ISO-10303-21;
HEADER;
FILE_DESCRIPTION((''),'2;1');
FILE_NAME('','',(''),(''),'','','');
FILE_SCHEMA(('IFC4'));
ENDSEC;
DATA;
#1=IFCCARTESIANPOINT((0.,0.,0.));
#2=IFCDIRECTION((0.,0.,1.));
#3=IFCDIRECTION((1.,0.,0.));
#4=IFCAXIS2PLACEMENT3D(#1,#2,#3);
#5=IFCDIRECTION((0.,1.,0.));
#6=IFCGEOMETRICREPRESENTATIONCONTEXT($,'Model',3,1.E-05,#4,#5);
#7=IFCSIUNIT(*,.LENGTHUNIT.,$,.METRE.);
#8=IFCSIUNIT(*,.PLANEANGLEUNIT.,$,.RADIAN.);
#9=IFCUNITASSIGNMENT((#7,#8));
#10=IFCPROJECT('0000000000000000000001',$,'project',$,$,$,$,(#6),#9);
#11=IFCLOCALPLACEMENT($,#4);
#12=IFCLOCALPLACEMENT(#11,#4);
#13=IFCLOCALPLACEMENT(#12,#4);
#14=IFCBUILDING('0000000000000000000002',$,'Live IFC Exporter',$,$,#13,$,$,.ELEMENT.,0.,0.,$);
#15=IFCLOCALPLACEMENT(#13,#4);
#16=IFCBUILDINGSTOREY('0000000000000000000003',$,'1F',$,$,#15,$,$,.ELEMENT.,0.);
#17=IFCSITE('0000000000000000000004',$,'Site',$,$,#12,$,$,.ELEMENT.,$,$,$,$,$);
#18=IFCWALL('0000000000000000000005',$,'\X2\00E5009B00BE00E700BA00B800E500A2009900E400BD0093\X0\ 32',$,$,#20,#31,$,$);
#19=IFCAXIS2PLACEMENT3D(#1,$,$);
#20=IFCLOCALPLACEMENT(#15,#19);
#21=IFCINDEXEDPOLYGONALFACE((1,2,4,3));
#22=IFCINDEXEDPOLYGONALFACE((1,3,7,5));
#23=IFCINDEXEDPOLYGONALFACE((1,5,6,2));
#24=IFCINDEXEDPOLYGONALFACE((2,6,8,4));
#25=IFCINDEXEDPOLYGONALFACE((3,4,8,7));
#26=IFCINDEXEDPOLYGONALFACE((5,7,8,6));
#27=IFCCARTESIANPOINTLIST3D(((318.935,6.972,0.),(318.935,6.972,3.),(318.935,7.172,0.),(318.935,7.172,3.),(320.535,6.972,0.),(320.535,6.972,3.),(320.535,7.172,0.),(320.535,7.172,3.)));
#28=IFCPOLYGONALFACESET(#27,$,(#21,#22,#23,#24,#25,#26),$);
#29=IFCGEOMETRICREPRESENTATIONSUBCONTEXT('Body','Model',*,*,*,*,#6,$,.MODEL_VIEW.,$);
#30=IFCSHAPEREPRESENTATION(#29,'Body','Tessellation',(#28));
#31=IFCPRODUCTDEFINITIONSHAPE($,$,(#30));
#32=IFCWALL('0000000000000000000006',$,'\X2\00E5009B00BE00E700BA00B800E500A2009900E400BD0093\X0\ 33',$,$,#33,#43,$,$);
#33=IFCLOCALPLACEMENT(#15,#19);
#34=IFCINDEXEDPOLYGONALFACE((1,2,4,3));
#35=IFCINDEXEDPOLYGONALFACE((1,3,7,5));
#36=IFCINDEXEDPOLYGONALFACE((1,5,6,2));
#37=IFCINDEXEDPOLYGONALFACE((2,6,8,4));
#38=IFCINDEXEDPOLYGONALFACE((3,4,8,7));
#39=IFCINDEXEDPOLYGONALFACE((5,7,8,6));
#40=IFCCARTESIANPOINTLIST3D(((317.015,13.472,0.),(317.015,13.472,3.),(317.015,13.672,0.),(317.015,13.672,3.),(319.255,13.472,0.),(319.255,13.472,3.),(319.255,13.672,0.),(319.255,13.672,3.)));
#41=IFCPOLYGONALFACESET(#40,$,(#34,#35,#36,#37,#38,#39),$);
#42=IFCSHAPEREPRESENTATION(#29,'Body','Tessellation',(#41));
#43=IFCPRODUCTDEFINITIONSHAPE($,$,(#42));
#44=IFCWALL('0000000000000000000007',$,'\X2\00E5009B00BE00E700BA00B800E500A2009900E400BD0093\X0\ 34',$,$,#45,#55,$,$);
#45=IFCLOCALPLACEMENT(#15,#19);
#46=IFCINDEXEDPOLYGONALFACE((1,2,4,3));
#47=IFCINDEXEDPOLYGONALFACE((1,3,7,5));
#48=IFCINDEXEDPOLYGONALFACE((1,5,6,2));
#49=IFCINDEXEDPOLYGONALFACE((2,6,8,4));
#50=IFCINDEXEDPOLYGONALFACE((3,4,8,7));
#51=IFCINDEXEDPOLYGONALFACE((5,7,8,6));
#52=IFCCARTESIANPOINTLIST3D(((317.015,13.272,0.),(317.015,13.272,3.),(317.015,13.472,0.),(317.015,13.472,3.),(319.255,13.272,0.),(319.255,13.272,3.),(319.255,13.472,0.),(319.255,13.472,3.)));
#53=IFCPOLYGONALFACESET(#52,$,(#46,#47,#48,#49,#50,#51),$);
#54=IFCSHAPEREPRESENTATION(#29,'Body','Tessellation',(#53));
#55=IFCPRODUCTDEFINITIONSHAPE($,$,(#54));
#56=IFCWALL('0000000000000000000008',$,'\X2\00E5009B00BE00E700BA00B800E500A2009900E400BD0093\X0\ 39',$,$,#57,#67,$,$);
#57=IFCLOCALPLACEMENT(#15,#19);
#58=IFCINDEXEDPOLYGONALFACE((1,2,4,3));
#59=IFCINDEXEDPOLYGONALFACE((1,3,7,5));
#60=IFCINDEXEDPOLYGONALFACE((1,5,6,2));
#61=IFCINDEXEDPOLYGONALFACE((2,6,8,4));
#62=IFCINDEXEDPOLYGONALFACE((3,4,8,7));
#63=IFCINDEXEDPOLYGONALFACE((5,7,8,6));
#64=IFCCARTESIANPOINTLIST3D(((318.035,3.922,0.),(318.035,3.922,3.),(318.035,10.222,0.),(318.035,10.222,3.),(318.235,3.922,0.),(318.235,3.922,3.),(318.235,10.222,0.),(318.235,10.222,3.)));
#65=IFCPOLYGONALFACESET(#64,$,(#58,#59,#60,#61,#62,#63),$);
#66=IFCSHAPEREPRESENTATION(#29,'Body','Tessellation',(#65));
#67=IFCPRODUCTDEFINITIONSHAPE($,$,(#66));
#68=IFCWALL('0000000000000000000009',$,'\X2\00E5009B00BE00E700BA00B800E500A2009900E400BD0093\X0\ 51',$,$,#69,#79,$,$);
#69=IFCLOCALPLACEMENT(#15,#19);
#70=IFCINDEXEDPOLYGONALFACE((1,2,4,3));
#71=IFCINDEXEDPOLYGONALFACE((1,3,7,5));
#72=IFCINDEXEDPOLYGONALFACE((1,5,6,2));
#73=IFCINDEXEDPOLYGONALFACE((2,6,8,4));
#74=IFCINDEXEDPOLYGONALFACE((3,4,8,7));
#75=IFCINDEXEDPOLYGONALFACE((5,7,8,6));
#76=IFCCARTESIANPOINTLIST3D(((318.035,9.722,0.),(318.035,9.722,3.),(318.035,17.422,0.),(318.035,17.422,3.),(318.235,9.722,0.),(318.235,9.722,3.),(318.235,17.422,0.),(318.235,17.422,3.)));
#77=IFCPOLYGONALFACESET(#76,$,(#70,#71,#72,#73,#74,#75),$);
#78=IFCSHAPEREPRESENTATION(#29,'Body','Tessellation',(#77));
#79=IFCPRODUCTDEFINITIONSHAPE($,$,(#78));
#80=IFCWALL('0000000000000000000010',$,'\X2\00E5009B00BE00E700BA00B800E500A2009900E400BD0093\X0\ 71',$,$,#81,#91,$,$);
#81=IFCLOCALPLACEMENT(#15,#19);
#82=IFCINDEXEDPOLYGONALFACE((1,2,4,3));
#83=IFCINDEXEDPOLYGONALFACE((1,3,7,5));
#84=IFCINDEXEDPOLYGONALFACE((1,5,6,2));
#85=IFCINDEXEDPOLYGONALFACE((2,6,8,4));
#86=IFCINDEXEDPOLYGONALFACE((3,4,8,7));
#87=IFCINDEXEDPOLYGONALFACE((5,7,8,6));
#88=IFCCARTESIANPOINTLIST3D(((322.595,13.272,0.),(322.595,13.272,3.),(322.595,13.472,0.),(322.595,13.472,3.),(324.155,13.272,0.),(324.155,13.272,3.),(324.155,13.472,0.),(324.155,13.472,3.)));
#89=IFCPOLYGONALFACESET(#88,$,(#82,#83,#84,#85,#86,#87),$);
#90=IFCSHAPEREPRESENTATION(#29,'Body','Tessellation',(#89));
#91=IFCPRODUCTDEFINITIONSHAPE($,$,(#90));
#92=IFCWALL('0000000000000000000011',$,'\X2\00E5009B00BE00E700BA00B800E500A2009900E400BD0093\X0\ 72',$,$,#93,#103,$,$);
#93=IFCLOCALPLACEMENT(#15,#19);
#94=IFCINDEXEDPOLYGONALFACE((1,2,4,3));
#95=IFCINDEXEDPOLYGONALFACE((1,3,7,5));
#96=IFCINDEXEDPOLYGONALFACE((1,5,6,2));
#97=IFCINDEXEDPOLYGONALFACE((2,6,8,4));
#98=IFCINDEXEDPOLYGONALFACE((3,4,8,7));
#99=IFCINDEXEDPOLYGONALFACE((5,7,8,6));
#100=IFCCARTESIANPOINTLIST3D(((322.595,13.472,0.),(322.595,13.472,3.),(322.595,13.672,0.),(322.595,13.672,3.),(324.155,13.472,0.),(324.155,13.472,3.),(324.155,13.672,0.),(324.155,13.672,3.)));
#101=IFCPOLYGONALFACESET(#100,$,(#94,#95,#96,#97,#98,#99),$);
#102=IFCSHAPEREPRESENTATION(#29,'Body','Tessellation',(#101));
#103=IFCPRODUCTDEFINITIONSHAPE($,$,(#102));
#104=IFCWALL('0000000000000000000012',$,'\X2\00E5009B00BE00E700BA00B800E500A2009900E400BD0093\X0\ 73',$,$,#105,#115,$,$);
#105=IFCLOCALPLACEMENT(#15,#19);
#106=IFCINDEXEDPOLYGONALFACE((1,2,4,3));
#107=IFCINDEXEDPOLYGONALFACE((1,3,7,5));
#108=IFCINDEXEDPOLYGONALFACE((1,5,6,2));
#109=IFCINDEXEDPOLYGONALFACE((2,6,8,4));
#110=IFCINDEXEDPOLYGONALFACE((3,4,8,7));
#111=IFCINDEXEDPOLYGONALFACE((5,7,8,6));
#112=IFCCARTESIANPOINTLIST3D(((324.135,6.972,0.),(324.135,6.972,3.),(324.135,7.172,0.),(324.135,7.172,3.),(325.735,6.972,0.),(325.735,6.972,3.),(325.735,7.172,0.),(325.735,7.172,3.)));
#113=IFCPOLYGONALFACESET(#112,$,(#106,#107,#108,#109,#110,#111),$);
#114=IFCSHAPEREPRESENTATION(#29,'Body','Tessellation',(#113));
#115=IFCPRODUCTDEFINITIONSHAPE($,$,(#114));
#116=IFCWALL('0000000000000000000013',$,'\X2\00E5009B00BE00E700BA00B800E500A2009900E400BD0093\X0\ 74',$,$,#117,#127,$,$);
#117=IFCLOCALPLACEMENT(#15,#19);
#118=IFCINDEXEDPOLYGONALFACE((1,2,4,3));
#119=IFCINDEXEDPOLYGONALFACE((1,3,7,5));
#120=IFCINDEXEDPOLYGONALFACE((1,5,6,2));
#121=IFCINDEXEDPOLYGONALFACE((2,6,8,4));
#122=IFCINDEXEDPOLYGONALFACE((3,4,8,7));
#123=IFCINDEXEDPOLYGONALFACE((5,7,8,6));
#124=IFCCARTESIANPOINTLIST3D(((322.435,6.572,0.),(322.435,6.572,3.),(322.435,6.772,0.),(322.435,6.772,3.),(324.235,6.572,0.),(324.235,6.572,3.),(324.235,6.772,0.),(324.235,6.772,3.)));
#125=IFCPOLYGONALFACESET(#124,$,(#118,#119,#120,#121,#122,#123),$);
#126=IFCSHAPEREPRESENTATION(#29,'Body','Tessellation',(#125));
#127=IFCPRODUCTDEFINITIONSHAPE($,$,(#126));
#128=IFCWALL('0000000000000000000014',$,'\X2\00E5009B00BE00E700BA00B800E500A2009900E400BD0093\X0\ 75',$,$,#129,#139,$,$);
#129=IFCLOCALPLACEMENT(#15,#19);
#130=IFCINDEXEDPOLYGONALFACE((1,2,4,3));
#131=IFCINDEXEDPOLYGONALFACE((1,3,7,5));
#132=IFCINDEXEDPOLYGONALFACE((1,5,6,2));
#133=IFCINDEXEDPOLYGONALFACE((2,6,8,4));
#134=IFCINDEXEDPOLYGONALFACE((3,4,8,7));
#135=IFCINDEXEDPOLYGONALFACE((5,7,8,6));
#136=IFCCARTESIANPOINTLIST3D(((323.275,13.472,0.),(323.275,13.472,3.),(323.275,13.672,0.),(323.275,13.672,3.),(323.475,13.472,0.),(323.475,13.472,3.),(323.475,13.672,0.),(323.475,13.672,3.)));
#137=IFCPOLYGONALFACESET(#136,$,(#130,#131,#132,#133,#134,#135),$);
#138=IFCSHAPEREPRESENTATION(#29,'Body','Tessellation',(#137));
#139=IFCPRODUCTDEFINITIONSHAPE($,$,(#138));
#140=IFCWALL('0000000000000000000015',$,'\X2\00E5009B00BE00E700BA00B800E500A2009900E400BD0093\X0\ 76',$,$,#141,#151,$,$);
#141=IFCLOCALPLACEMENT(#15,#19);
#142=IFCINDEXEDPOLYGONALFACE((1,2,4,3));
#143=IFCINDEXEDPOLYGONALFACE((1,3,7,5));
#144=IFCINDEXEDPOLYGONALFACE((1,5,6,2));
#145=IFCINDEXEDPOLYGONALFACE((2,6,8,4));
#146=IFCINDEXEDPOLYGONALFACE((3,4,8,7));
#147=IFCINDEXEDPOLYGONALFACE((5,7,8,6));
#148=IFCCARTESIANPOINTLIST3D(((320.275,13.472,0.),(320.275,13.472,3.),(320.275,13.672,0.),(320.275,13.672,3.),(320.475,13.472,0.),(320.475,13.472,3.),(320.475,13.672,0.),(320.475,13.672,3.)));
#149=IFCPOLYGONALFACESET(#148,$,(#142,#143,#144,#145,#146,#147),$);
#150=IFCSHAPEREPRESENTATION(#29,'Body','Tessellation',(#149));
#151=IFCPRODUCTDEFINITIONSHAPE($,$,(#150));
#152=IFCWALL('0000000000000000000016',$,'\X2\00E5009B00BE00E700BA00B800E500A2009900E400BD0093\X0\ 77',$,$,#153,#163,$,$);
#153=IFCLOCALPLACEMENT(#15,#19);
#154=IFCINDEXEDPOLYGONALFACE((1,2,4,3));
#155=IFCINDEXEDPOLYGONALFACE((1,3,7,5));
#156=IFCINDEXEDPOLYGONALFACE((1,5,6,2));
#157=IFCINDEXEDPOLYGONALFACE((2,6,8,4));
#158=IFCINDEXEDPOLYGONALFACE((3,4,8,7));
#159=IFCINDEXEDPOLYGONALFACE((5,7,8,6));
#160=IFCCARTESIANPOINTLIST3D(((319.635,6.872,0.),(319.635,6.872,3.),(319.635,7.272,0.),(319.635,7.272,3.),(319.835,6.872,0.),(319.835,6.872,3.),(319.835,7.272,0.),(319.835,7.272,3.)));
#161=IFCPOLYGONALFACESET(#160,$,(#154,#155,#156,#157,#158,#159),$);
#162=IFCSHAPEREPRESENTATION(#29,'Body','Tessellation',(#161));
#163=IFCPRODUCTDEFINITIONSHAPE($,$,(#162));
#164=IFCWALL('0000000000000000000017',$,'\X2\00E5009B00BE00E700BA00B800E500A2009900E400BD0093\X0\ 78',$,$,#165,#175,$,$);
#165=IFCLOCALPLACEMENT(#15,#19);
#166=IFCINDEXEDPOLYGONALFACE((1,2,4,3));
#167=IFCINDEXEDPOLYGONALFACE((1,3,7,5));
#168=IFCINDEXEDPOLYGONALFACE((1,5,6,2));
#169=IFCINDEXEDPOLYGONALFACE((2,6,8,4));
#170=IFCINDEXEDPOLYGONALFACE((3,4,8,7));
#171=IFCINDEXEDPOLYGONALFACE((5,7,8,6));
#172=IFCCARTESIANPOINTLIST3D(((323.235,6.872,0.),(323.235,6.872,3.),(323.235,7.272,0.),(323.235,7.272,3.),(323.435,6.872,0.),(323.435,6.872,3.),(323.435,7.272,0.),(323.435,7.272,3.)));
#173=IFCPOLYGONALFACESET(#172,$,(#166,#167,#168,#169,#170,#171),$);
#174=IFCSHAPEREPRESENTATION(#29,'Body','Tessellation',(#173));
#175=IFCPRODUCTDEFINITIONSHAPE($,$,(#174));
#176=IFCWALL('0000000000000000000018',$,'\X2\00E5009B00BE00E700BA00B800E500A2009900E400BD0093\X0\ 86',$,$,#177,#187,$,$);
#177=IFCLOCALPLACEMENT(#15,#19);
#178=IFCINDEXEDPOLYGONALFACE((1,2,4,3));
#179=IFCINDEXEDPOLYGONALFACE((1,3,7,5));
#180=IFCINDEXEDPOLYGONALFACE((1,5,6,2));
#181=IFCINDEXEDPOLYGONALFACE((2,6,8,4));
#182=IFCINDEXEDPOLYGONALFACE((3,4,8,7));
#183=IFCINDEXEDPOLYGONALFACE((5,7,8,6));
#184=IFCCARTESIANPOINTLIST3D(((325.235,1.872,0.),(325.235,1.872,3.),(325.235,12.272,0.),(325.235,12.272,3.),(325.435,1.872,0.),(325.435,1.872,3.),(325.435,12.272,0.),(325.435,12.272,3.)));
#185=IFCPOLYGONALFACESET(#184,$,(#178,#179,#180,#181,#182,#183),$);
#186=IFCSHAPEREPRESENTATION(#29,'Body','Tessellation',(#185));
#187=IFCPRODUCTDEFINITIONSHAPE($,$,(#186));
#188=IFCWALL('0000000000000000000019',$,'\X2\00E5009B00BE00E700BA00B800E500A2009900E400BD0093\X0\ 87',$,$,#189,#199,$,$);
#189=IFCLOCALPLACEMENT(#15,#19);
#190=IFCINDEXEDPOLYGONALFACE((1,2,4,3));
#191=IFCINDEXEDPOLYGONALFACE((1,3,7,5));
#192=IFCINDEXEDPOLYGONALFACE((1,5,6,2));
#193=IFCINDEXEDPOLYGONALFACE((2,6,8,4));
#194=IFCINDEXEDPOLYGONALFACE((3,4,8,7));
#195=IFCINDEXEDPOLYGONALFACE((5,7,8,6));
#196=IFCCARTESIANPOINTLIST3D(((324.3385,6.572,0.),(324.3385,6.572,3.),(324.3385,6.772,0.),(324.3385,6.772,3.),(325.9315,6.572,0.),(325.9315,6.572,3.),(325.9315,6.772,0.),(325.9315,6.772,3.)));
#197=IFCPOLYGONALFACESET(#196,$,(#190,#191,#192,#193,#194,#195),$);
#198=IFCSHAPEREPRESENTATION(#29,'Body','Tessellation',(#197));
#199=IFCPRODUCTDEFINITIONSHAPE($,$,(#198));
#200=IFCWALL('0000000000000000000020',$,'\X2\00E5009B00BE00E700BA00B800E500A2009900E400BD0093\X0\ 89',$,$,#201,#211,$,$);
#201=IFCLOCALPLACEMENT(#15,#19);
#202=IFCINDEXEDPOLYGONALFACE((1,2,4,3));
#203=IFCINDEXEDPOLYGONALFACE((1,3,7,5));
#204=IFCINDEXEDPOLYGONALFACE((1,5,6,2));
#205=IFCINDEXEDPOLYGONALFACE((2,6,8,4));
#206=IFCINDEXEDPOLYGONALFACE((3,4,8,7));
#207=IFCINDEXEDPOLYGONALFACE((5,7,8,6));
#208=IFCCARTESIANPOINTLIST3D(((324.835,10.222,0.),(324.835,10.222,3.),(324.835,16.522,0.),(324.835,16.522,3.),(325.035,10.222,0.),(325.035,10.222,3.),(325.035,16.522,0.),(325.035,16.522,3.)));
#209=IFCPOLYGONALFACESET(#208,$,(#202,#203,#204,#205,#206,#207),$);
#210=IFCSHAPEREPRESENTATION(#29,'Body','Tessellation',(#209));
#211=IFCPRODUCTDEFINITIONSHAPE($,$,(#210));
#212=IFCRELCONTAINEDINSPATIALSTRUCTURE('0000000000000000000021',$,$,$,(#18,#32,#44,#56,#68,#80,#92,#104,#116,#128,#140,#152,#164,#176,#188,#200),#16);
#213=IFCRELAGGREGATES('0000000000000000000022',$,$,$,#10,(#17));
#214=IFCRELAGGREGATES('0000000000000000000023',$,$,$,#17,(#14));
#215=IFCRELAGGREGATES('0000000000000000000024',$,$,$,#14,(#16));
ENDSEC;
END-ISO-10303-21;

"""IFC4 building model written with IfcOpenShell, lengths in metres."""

from ifc_helpers import new_model, si_unit, direction, frame, frame_2d, origin_with_axes, place, context, subcontext, project, spatial, rectangle, extrude, element, save


model = new_model("IFC4")

# Units and contexts
model_context = context("Model", 3, precision=1e-05, world=origin_with_axes(), true_north=direction((0.0, 1.0, 0.0)))
body_context = subcontext(model_context, "Body", "Model", "MODEL_VIEW")
ifc_project = project(units=[si_unit("LENGTHUNIT", "METRE"), si_unit("PLANEANGLEUNIT", "RADIAN")], contexts=[model_context])

# Site, building, storey
placement = place(None, origin_with_axes())
site_placement = place(placement, origin_with_axes())
site = spatial("IfcSite", under=ifc_project, at=site_placement, Name="Site", CompositionType="ELEMENT")
building_placement = place(site_placement, origin_with_axes())
building = spatial("IfcBuilding", under=site, at=building_placement, Name="Live IFC Exporter", CompositionType="ELEMENT", ElevationOfRefHeight=0.0, ElevationOfTerrain=0.0)
storey_placement = place(building_placement, origin_with_axes())
storey = spatial("IfcBuildingStorey", under=building, at=storey_placement, Name="1F", CompositionType="ELEMENT", Elevation=0.0)

# Walls
wall_1_placement = place(storey_placement, frame((319.735, 7.072, 0.0), z_axis=(0.0, 0.0, 1.0), x_axis=(-1.0, 0.0, 0.0)))
element("IfcWall", 1, at=wall_1_placement, inside=storey, Name="å\u009b¾çº¸å¢\u0099ä½\u0093 32", context=body_context, shape_type="SweptSolid", body=[
    extrude(rectangle(XDim=1.6, YDim=0.2, at=frame_2d((0.0, 0.0), x_axis=(1.0, 0.0, 0.0))), frame((0.0, 0.0, 0.0), z_axis=(0.0, 0.0, 1.0)), (0.0, 0.0, 1.0), 3.0),
])
for number, where, z_axis, x_axis, name in (
    (2, (318.135, 13.572, 0.0), (0.0, 0.0, 1.0), (1.0, 0.0, 0.0), "å\u009b¾çº¸å¢\u0099ä½\u0093 33"),
    (3, (318.135, 13.372, 0.0), (0.0, 0.0, 1.0), (1.0, 0.0, 0.0), "å\u009b¾çº¸å¢\u0099ä½\u0093 34"),
):
    element("IfcWall", number, at=place(storey_placement, frame(where, z_axis=z_axis, x_axis=x_axis)), inside=storey, Name=name, context=body_context, shape_type="SweptSolid", body=[
        extrude(rectangle(XDim=2.24, YDim=0.2, at=frame_2d((0.0, 0.0), x_axis=(1.0, 0.0, 0.0))), frame((0.0, 0.0, 0.0), z_axis=(0.0, 0.0, 1.0)), (0.0, 0.0, 1.0), 3.0),
    ])
wall_2_placement = place(storey_placement, frame((318.135, 7.072, 0.0), z_axis=(0.0, 0.0, 1.0), x_axis=(0.0, 1.0, 0.0)))
element("IfcWall", 4, at=wall_2_placement, inside=storey, Name="å\u009b¾çº¸å¢\u0099ä½\u0093 39", context=body_context, shape_type="SweptSolid", body=[
    extrude(rectangle(XDim=6.3, YDim=0.2, at=frame_2d((0.0, 0.0), x_axis=(1.0, 0.0, 0.0))), frame((0.0, 0.0, 0.0), z_axis=(0.0, 0.0, 1.0)), (0.0, 0.0, 1.0), 3.0),
])
wall_3_placement = place(storey_placement, frame((318.135, 13.572, 0.0), z_axis=(0.0, 0.0, 1.0), x_axis=(0.0, 1.0, 0.0)))
element("IfcWall", 5, at=wall_3_placement, inside=storey, Name="å\u009b¾çº¸å¢\u0099ä½\u0093 51", context=body_context, shape_type="SweptSolid", body=[
    extrude(rectangle(XDim=7.7, YDim=0.2, at=frame_2d((0.0, 0.0), x_axis=(1.0, 0.0, 0.0))), frame((0.0, 0.0, 0.0), z_axis=(0.0, 0.0, 1.0)), (0.0, 0.0, 1.0), 3.0),
])
for number, where, z_axis, x_axis, name in (
    (6, (323.375, 13.372, 0.0), (0.0, 0.0, 1.0), (1.0, 0.0, 0.0), "å\u009b¾çº¸å¢\u0099ä½\u0093 71"),
    (7, (323.375, 13.572, 0.0), (0.0, 0.0, 1.0), (1.0, 0.0, 0.0), "å\u009b¾çº¸å¢\u0099ä½\u0093 72"),
):
    element("IfcWall", number, at=place(storey_placement, frame(where, z_axis=z_axis, x_axis=x_axis)), inside=storey, Name=name, context=body_context, shape_type="SweptSolid", body=[
        extrude(rectangle(XDim=1.56, YDim=0.2, at=frame_2d((0.0, 0.0), x_axis=(1.0, 0.0, 0.0))), frame((0.0, 0.0, 0.0), z_axis=(0.0, 0.0, 1.0)), (0.0, 0.0, 1.0), 3.0),
    ])
wall_4_placement = place(storey_placement, frame((324.935, 7.072, 0.0), z_axis=(0.0, 0.0, 1.0), x_axis=(-1.0, 0.0, 0.0)))
element("IfcWall", 8, at=wall_4_placement, inside=storey, Name="å\u009b¾çº¸å¢\u0099ä½\u0093 73", context=body_context, shape_type="SweptSolid", body=[
    extrude(rectangle(XDim=1.6, YDim=0.2, at=frame_2d((0.0, 0.0), x_axis=(1.0, 0.0, 0.0))), frame((0.0, 0.0, 0.0), z_axis=(0.0, 0.0, 1.0)), (0.0, 0.0, 1.0), 3.0),
])
wall_5_placement = place(storey_placement, frame((323.335, 6.672, 0.0), z_axis=(0.0, 0.0, 1.0), x_axis=(1.0, 0.0, 0.0)))
element("IfcWall", 9, at=wall_5_placement, inside=storey, Name="å\u009b¾çº¸å¢\u0099ä½\u0093 74", context=body_context, shape_type="SweptSolid", body=[
    extrude(rectangle(XDim=1.8, YDim=0.2, at=frame_2d((0.0, 0.0), x_axis=(1.0, 0.0, 0.0))), frame((0.0, 0.0, 0.0), z_axis=(0.0, 0.0, 1.0)), (0.0, 0.0, 1.0), 3.0),
])
for number, where, z_axis, x_axis, name in (
    (10, (323.375, 13.572, 0.0), (0.0, 0.0, 1.0), (0.0, -1.0, 0.0), "å\u009b¾çº¸å¢\u0099ä½\u0093 75"),
    (11, (320.375, 13.572, 0.0), (0.0, 0.0, 1.0), (0.0, -1.0, 0.0), "å\u009b¾çº¸å¢\u0099ä½\u0093 76"),
):
    element("IfcWall", number, at=place(storey_placement, frame(where, z_axis=z_axis, x_axis=x_axis)), inside=storey, Name=name, context=body_context, shape_type="SweptSolid", body=[
        extrude(rectangle(XDim=0.2, YDim=0.2, at=frame_2d((0.0, 0.0), x_axis=(1.0, 0.0, 0.0))), frame((0.0, 0.0, 0.0), z_axis=(0.0, 0.0, 1.0)), (0.0, 0.0, 1.0), 3.0),
    ])
for number, where, z_axis, x_axis, name in (
    (12, (319.735, 7.072, 0.0), (0.0, 0.0, 1.0), (0.0, -1.0, 0.0), "å\u009b¾çº¸å¢\u0099ä½\u0093 77"),
    (13, (323.335, 7.072, 0.0), (0.0, 0.0, 1.0), (0.0, -1.0, 0.0), "å\u009b¾çº¸å¢\u0099ä½\u0093 78"),
):
    element("IfcWall", number, at=place(storey_placement, frame(where, z_axis=z_axis, x_axis=x_axis)), inside=storey, Name=name, context=body_context, shape_type="SweptSolid", body=[
        extrude(rectangle(XDim=0.4, YDim=0.2, at=frame_2d((0.0, 0.0), x_axis=(1.0, 0.0, 0.0))), frame((0.0, 0.0, 0.0), z_axis=(0.0, 0.0, 1.0)), (0.0, 0.0, 1.0), 3.0),
    ])
wall_6_placement = place(storey_placement, frame((325.335, 7.072, 0.0), z_axis=(0.0, 0.0, 1.0), x_axis=(0.0, 1.0, 0.0)))
element("IfcWall", 14, at=wall_6_placement, inside=storey, Name="å\u009b¾çº¸å¢\u0099ä½\u0093 86", context=body_context, shape_type="SweptSolid", body=[
    extrude(rectangle(XDim=10.4, YDim=0.2, at=frame_2d((0.0, 0.0), x_axis=(1.0, 0.0, 0.0))), frame((0.0, 0.0, 0.0), z_axis=(0.0, 0.0, 1.0)), (0.0, 0.0, 1.0), 3.0),
])
wall_7_placement = place(storey_placement, frame((325.135, 6.672, 0.0), z_axis=(0.0, 0.0, 1.0), x_axis=(1.0, 0.0, 0.0)))
element("IfcWall", 15, at=wall_7_placement, inside=storey, Name="å\u009b¾çº¸å¢\u0099ä½\u0093 87", context=body_context, shape_type="SweptSolid", body=[
    extrude(rectangle(XDim=1.593, YDim=0.2, at=frame_2d((0.0, 0.0), x_axis=(1.0, 0.0, 0.0))), frame((0.0, 0.0, 0.0), z_axis=(0.0, 0.0, 1.0)), (0.0, 0.0, 1.0), 3.0),
])
wall_8_placement = place(storey_placement, frame((324.935, 13.372, 0.0), z_axis=(0.0, 0.0, 1.0), x_axis=(0.0, -1.0, 0.0)))
element("IfcWall", 16, at=wall_8_placement, inside=storey, Name="å\u009b¾çº¸å¢\u0099ä½\u0093 89", context=body_context, shape_type="SweptSolid", body=[
    extrude(rectangle(XDim=6.3, YDim=0.2, at=frame_2d((0.0, 0.0), x_axis=(1.0, 0.0, 0.0))), frame((0.0, 0.0, 0.0), z_axis=(0.0, 0.0, 1.0)), (0.0, 0.0, 1.0), 3.0),
])

save(model, "model.ifc")
